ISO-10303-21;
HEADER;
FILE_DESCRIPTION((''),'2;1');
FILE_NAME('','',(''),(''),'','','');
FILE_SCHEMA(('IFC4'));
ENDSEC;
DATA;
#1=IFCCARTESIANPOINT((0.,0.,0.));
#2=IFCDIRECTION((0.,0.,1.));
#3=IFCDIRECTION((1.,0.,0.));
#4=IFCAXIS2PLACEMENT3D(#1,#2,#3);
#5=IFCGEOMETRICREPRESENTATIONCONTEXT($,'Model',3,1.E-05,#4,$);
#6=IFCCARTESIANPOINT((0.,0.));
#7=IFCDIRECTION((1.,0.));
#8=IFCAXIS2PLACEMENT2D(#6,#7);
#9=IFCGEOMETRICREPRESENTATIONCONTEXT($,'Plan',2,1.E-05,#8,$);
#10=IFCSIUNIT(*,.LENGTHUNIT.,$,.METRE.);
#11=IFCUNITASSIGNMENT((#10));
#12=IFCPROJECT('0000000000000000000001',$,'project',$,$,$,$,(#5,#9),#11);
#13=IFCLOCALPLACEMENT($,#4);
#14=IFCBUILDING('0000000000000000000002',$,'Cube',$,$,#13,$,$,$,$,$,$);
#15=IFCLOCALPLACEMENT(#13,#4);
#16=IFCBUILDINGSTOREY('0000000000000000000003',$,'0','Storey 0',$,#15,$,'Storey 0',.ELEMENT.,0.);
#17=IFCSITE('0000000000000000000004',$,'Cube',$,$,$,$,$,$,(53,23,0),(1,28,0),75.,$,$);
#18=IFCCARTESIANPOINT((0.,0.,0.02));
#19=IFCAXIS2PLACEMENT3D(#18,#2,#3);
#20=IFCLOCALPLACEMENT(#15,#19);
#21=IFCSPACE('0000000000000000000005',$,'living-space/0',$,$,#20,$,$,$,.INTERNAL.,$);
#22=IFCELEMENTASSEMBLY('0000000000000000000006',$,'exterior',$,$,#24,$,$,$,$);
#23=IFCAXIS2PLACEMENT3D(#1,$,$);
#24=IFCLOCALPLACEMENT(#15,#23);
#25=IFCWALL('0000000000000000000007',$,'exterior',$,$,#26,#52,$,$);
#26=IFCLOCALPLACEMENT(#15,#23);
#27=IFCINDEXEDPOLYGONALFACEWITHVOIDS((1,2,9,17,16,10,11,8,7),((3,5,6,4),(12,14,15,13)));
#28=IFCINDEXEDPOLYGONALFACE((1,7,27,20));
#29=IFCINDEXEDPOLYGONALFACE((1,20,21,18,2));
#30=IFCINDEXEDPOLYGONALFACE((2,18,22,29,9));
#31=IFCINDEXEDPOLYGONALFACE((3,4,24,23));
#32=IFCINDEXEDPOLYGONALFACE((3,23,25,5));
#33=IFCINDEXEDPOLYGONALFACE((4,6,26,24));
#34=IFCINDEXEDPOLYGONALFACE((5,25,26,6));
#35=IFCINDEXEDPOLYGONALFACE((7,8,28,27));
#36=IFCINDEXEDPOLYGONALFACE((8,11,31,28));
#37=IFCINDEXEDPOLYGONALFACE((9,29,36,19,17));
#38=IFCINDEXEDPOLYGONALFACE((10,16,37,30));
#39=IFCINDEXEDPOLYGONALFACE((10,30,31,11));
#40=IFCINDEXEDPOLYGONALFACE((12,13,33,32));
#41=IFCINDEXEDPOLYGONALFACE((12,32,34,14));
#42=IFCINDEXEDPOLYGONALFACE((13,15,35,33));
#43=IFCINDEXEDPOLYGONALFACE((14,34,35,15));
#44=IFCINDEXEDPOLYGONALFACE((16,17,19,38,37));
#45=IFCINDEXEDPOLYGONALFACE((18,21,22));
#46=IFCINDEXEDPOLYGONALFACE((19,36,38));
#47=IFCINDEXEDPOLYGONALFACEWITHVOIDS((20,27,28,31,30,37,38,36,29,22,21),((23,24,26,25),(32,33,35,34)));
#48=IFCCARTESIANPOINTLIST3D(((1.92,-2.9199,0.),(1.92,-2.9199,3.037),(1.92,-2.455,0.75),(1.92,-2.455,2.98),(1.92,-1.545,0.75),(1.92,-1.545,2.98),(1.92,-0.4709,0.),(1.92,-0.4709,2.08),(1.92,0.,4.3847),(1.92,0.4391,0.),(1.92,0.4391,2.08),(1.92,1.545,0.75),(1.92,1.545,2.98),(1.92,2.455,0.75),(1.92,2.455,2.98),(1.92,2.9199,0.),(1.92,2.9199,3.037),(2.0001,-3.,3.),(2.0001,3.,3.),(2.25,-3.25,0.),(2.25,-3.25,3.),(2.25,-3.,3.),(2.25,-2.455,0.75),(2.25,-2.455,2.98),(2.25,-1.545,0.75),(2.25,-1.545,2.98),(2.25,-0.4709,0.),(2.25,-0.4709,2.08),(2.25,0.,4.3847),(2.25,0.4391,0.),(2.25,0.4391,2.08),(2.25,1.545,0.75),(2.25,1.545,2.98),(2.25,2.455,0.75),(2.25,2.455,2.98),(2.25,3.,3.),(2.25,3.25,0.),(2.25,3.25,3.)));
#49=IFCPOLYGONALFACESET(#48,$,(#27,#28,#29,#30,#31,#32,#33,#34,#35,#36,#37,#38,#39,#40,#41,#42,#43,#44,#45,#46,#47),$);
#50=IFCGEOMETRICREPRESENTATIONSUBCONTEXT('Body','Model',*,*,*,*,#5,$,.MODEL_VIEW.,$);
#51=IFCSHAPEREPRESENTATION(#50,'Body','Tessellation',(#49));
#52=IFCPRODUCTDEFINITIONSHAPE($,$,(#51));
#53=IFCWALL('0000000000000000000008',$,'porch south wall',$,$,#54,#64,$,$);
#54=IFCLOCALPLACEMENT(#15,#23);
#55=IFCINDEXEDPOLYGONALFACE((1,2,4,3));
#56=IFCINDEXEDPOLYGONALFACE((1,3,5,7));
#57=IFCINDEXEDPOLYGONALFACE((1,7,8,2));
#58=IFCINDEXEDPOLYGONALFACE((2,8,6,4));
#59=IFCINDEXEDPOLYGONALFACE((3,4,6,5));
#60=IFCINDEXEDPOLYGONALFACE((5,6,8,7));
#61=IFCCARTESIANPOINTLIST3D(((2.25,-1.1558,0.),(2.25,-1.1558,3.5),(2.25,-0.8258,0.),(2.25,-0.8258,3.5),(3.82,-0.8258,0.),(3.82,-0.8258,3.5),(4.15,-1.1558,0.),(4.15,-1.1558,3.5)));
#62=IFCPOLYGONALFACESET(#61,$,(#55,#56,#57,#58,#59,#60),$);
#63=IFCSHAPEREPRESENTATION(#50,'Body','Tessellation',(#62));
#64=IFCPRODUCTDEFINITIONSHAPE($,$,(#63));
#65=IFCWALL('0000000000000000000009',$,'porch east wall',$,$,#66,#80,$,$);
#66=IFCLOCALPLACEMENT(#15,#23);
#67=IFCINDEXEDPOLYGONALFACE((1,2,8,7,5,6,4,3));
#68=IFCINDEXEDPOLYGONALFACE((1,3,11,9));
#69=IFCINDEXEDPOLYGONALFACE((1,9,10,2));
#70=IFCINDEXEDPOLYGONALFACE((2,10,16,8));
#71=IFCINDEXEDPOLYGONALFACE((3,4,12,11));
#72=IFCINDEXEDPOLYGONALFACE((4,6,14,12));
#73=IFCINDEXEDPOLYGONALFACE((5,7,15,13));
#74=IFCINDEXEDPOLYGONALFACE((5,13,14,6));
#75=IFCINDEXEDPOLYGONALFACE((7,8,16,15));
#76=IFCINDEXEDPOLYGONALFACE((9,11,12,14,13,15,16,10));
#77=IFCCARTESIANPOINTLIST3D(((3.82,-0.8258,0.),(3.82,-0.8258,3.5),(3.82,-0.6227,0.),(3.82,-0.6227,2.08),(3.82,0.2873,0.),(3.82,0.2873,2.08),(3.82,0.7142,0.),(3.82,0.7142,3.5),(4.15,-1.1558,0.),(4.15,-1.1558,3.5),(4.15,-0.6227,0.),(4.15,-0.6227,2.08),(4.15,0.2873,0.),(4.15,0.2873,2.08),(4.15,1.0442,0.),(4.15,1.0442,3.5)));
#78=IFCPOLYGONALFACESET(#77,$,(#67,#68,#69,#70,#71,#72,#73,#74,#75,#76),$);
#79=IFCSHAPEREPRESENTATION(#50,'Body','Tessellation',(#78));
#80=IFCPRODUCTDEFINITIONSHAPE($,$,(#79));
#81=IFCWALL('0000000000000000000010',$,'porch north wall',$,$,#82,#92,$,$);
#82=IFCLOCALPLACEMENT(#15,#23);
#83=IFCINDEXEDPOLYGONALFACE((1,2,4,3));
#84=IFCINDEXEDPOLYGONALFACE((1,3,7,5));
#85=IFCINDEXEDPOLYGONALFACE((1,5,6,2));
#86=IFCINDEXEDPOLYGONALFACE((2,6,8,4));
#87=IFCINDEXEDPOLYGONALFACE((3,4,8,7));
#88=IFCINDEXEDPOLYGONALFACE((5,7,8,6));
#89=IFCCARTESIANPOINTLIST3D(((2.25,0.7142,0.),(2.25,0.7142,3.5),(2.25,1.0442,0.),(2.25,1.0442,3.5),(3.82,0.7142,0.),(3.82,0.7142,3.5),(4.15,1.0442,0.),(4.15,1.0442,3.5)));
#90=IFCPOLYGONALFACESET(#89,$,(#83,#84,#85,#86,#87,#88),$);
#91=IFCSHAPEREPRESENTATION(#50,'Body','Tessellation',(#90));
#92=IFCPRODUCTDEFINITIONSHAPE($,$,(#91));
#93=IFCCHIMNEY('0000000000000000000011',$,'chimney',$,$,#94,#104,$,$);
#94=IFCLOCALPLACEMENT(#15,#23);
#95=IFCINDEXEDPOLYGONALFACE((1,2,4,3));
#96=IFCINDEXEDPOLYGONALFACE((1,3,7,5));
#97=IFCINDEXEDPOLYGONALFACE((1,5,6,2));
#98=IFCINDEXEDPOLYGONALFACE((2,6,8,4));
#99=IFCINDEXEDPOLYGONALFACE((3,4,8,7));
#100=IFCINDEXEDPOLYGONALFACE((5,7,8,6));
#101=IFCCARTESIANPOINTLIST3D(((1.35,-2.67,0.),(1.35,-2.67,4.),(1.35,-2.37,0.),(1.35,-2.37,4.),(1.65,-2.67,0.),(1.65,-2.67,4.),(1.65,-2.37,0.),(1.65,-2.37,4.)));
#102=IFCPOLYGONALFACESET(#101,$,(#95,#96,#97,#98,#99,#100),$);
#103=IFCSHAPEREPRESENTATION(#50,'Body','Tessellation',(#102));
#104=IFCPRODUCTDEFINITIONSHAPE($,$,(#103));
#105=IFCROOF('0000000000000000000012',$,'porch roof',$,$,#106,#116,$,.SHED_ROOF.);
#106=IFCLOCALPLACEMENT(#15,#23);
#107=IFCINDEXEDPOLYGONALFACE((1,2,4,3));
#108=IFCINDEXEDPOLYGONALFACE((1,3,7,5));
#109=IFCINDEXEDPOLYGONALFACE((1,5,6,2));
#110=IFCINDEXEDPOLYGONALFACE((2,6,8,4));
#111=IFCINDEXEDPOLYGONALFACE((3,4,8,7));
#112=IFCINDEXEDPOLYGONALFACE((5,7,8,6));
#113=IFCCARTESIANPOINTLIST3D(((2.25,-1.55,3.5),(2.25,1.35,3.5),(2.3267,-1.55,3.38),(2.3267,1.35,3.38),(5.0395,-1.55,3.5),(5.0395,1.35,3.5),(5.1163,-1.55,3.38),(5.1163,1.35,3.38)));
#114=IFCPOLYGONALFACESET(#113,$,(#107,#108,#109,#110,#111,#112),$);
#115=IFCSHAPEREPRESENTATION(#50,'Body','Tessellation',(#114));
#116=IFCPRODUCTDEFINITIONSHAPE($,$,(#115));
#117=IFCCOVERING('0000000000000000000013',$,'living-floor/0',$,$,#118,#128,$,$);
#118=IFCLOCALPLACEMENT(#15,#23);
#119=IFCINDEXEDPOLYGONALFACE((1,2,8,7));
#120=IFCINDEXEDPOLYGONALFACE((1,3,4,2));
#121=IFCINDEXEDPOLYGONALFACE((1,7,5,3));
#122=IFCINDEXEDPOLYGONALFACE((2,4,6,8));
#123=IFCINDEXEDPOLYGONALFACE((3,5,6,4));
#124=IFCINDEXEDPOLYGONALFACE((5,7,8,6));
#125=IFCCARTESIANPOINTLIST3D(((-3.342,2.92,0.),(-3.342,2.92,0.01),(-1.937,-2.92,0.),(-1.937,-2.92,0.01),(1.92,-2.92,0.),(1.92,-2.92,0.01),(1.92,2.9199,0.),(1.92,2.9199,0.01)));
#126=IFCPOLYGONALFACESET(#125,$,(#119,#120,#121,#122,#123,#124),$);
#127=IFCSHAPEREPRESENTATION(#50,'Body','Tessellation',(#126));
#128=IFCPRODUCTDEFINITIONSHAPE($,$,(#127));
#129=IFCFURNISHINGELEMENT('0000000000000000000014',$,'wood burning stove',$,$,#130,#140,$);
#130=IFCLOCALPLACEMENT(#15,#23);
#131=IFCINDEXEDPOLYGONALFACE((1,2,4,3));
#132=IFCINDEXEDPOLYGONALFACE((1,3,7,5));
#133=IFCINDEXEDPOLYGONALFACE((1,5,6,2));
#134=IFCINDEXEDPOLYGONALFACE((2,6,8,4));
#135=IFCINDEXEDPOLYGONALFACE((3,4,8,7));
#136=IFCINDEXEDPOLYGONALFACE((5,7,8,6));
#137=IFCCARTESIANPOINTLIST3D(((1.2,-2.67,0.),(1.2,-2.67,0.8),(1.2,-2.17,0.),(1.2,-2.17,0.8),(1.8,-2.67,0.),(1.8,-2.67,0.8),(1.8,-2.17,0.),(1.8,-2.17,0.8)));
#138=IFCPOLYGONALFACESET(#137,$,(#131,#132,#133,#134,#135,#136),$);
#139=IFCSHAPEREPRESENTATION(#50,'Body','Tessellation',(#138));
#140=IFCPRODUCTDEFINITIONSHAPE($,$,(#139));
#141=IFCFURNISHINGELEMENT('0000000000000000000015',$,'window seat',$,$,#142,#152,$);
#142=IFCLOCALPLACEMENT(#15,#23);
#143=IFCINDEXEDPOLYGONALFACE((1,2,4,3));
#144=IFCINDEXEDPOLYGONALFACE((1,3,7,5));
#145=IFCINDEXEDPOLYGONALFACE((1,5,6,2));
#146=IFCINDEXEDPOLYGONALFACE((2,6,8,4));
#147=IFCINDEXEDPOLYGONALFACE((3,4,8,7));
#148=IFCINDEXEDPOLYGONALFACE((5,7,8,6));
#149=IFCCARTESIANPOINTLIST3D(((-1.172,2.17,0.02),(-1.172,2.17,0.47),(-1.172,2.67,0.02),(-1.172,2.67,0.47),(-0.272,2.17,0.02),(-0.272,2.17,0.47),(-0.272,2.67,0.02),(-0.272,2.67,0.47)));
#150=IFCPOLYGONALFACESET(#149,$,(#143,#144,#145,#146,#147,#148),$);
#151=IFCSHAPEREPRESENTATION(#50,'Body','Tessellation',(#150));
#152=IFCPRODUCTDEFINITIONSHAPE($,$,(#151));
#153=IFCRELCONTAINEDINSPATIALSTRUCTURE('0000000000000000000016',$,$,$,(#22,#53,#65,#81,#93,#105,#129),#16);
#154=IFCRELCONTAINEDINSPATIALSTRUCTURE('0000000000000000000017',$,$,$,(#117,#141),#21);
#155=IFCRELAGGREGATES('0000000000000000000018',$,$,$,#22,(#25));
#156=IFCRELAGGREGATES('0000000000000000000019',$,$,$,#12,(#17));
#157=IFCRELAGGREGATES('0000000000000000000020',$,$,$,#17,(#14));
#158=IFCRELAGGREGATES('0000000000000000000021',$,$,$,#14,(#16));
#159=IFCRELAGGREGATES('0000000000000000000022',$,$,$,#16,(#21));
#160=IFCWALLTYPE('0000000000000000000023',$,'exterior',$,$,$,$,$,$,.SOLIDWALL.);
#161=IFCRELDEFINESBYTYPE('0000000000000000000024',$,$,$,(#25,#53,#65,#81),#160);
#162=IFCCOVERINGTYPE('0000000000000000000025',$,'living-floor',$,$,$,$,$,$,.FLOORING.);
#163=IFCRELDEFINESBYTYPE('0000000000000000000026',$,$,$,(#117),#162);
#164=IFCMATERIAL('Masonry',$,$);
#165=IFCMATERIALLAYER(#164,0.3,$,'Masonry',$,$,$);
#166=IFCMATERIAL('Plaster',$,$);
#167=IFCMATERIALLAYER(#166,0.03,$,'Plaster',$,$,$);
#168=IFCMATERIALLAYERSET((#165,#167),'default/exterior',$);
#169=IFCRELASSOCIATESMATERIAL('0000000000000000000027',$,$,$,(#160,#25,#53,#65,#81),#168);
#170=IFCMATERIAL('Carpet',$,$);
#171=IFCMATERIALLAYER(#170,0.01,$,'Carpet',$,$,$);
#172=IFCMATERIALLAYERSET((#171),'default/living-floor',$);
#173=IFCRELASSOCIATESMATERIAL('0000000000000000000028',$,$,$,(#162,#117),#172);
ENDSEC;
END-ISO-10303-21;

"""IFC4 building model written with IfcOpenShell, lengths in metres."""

from ifc_helpers import new_model, si_unit, frame, origin, origin_with_axes, origin_2d_with_axis, place, context, subcontext, project, spatial, polyline, line, indexed_curve, outline, extrude, clip, bounded_halfspace, source, transform, mapped, material, layer, layer_set, layer_usage, type_object, element, aggregate, save


model = new_model("IFC4")

# Units and contexts
model_context = context("Model", 3, precision=1e-05, world=origin_with_axes())
plan_context = context("Plan", 2, precision=1e-05, world=origin_2d_with_axis())
body_context = subcontext(model_context, "Body", "Model", "MODEL_VIEW")
ifc_project = project(units=[si_unit("LENGTHUNIT", "METRE")], contexts=[model_context, plan_context])

# Site, building, storey
site = spatial("IfcSite", under=ifc_project, Name="Cube", RefLatitude=(53, 23, 0), RefLongitude=(1, 28, 0), RefElevation=75.0)
building_placement = place(None, origin_with_axes())
building = spatial("IfcBuilding", under=site, at=building_placement, Name="Cube")
storey_placement = place(building_placement, origin_with_axes())
storey = spatial("IfcBuildingStorey", under=building, at=storey_placement, Name="0", Description="Storey 0", LongName="Storey 0", CompositionType="ELEMENT", Elevation=0.0)

# Element assembly, wall, openings
ifc_material_1 = material(Name="Masonry")
ifc_layer_1 = layer(ifc_material_1, 0.3, Name="Masonry")
ifc_material_2 = material(Name="Plaster")
ifc_layer_2 = layer(ifc_material_2, 0.03, Name="Plaster")
ifc_layer_set_1 = layer_set([ifc_layer_1, ifc_layer_2], Name="default/exterior")
wall_type = type_object("IfcWallType", Name="exterior", PredefinedType="SOLIDWALL", material=ifc_layer_set_1)
assembly_1_placement = place(storey_placement, frame((2.0, -3.0, 0.0), z_axis=(0.0, 0.0, 1.0), x_axis=(0.0, 1.0, 0.0)))
assembly_1 = element("IfcElementAssembly", 1, at=assembly_1_placement, inside=storey, Name="exterior")
ifc_layer_usage_1 = layer_usage(ifc_layer_set_1, "AXIS2", "POSITIVE", -0.25)
wall_1_placement = place(assembly_1_placement, origin_with_axes())
wall_1 = element("IfcWall", 2, at=wall_1_placement, type_object=wall_type, material=ifc_layer_usage_1, Name="exterior", context=body_context, shape_type="Clipping", body=[
    clip(clip(clip(clip(extrude(outline(polyline([(0.0801, 0.08), (-0.25, -0.25), (6.25, -0.25), (5.9199, 0.08), (0.0801, 0.08)])), origin(), (0.0, 0.0, 1.0), 4.385), bounded_halfspace(frame((6.0, 0.0, 3.0), z_axis=(0.419069, 0.0, 0.907954), x_axis=(0.0, -1.0, 0.0)), False, origin(), polyline([(6.0, -1.0), (3.0, -1.0), (3.0, 1.0), (6.0, 1.0), (6.0, -1.0)]))), bounded_halfspace(frame((6.0, 0.0, 3.0), z_axis=(0.0, 0.0, 1.0), x_axis=(0.0, 1.0, 0.0)), False, origin(), polyline([(6.0, 1.0), (7.0, 1.0), (7.0, -1.0), (6.0, -1.0), (6.0, 1.0)]))), bounded_halfspace(frame((3.0, 0.0, 4.3847), z_axis=(-0.419069, 0.0, 0.907954), x_axis=(0.0, -1.0, 0.0)), False, origin(), polyline([(3.0, -1.0), (0.0, -1.0), (0.0, 1.0), (3.0, 1.0), (3.0, -1.0)]))), bounded_halfspace(frame((0.0, 0.0, 3.0), z_axis=(0.0, 0.0, 1.0), x_axis=(0.0, -1.0, 0.0)), False, origin(), polyline([(0.0, -1.0), (-1.0, -1.0), (-1.0, 1.0), (0.0, 1.0), (0.0, -1.0)]))),
])
opening_1_placement = place(wall_1_placement, frame((0.545, -0.25, 0.75), z_axis=(0.0, 0.0, 1.0), x_axis=(1.0, 0.0, 0.0)))
element("IfcOpeningElement", 3, at=opening_1_placement, cuts=wall_1, PredefinedType="OPENING", context=body_context, shape_type="SweptSolid", body=[
    extrude(outline(polyline([(0.0, -0.02), (0.91, -0.02), (0.91, 0.35), (0.0, 0.35), (0.0, -0.02)])), origin(), (0.0, 0.0, 1.0), 2.23),
])
opening_2_placement = place(wall_1_placement, frame((4.545, -0.25, 0.75), z_axis=(0.0, 0.0, 1.0), x_axis=(1.0, 0.0, 0.0)))
element("IfcOpeningElement", 4, at=opening_2_placement, cuts=wall_1, PredefinedType="OPENING", context=body_context, shape_type="SweptSolid", body=[
    extrude(outline(polyline([(0.0, -0.02), (0.91, -0.02), (0.91, 0.35), (0.0, 0.35), (0.0, -0.02)])), origin(), (0.0, 0.0, 1.0), 2.23),
])
shared_shape_1 = source(origin_with_axes(), body_context, "Body", "SweptSolid", [
    extrude(outline(indexed_curve([(0.0, 0.0), (0.91, 0.0), (0.91, 2.08), (0.0, 2.08)], segments=[line(1, 2, 3, 4, 1)])), frame((0.0, -0.6, 0.0), z_axis=(0.0, -1.0, 0.0), x_axis=(1.0, 0.0, 0.0)), (0.0, 0.0, -1.0), 1.2),
])
opening_3_placement = place(wall_1_placement, frame((2.5291, -0.25, 0.0), z_axis=(0.0, 0.0, 1.0), x_axis=(1.0, 0.0, 0.0)))
element("IfcOpeningElement", 5, at=opening_3_placement, cuts=wall_1, PredefinedType="OPENING", context=body_context, shape_type="MappedRepresentation", body=[
    mapped(shared_shape_1, transform((0.0, 0.0, 0.0), x_axis=(1.0, 0.0, 0.0), y_axis=(0.0, 1.0, 0.0), z_axis=(0.0, 0.0, 1.0), scale=1.0)),
])
aggregate(assembly_1, [wall_1])

# Wall
ifc_layer_usage_2 = layer_usage(ifc_layer_set_1, "AXIS2", "POSITIVE", 0.0)
wall_2_placement = place(storey_placement, frame((2.25, -1.1558, 0.0), z_axis=(0.0, 0.0, 1.0), x_axis=(1.0, 0.0, 0.0)))
element("IfcWall", 6, at=wall_2_placement, inside=storey, type_object=wall_type, material=ifc_layer_usage_2, Name="porch south wall", context=body_context, shape_type="SweptSolid", body=[
    extrude(outline(indexed_curve([(0.0, 0.0), (0.0, 0.33), (1.57, 0.33), (1.9, 0.0)], segments=[line(1, 2, 3, 4, 1)])), origin_with_axes(), (0.0, 0.0, 1.0), 3.5),
])

# Wall, opening
ifc_layer_usage_3 = layer_usage(ifc_layer_set_1, "AXIS2", "POSITIVE", 0.0)
wall_3_placement = place(storey_placement, frame((4.15, -1.1558, 0.0), z_axis=(0.0, 0.0, 1.0), x_axis=(0.0, 1.0, 0.0)))
wall_3 = element("IfcWall", 7, at=wall_3_placement, inside=storey, type_object=wall_type, material=ifc_layer_usage_3, Name="porch east wall", context=body_context, shape_type="SweptSolid", body=[
    extrude(outline(indexed_curve([(0.0, 0.0), (0.33, 0.33), (1.87, 0.33), (2.2, 0.0)], segments=[line(1, 2, 3, 4, 1)])), origin_with_axes(), (0.0, 0.0, 1.0), 3.5),
])
shared_shape_2 = source(origin_with_axes(), body_context, "Body", "SweptSolid", [
    extrude(outline(indexed_curve([(0.0, 0.0), (0.91, 0.0), (0.91, 2.08), (0.0, 2.08)], segments=[line(1, 2, 3, 4, 1)])), frame((0.0, -0.6, 0.0), z_axis=(0.0, -1.0, 0.0), x_axis=(1.0, 0.0, 0.0)), (0.0, 0.0, -1.0), 1.2),
])
opening_4_placement = place(wall_3_placement, frame((0.5331, 0.0, 0.0), z_axis=(0.0, 0.0, 1.0), x_axis=(1.0, 0.0, 0.0)))
element("IfcOpeningElement", 8, at=opening_4_placement, cuts=wall_3, PredefinedType="OPENING", context=body_context, shape_type="MappedRepresentation", body=[
    mapped(shared_shape_2, transform((0.0, 0.0, 0.0), x_axis=(1.0, 0.0, 0.0), y_axis=(0.0, 1.0, 0.0), z_axis=(0.0, 0.0, 1.0), scale=1.0)),
])

# Wall
ifc_layer_usage_4 = layer_usage(ifc_layer_set_1, "AXIS2", "POSITIVE", 0.0)
wall_4_placement = place(storey_placement, frame((4.15, 1.0442, 0.0), z_axis=(0.0, 0.0, 1.0), x_axis=(-1.0, 0.0, 0.0)))
element("IfcWall", 9, at=wall_4_placement, inside=storey, type_object=wall_type, material=ifc_layer_usage_4, Name="porch north wall", context=body_context, shape_type="SweptSolid", body=[
    extrude(outline(indexed_curve([(0.0, 0.0), (0.33, 0.33), (1.9, 0.33), (1.9, 0.0)], segments=[line(1, 2, 3, 4, 1)])), origin_with_axes(), (0.0, 0.0, 1.0), 3.5),
])

# Chimney
chimney_placement = place(storey_placement, frame((1.35, -2.67, 0.0), z_axis=(0.0, 0.0, 1.0), x_axis=(1.0, 0.0, 0.0)))
element("IfcChimney", 10, at=chimney_placement, inside=storey, Name="chimney", context=body_context, shape_type="SweptSolid", body=[
    extrude(outline(indexed_curve([(0.0, 0.0), (0.3, 0.0), (0.3, 0.3), (0.0, 0.3)])), None, (0.0, 0.0, 1.0), 4.0),
])

# Roof
roof_placement = place(storey_placement, frame((2.25, 1.35, 3.5), z_axis=(0.0, 0.0, 1.0), x_axis=(0.0, -1.0, 0.0)))
element("IfcRoof", 11, at=roof_placement, inside=storey, Name="porch roof", PredefinedType="SHED_ROOF", context=body_context, shape_type="SweptSolid", body=[
    extrude(outline(indexed_curve([(0.0, 0.0), (2.9, 0.0), (2.9, 2.7895), (0.0, 2.7895)])), None, (0.0, 0.53879, -0.84244), 0.1424),
])

# Shared definitions
space_placement = place(storey_placement, frame((0.0, 0.0, 0.02), z_axis=(0.0, 0.0, 1.0), x_axis=(1.0, 0.0, 0.0)))
space = spatial("IfcSpace", under=storey, at=space_placement, Name="living-space/0", PredefinedType="INTERNAL")

# Covering
ifc_material_3 = material(Name="Carpet")
ifc_layer_3 = layer(ifc_material_3, 0.01, Name="Carpet")
ifc_layer_set_2 = layer_set([ifc_layer_3], Name="default/living-floor")
ifc_layer_usage_5 = layer_usage(ifc_layer_set_2, "AXIS3", "POSITIVE", 0.0)
covering_type = type_object("IfcCoveringType", Name="living-floor", PredefinedType="FLOORING", material=ifc_layer_set_2)
covering_placement = place(space_placement, frame((0.0, 0.0, -0.02), z_axis=(0.0, 0.0, 1.0), x_axis=(1.0, 0.0, 0.0)))
element("IfcCovering", 12, at=covering_placement, inside=space, type_object=covering_type, material=ifc_layer_usage_5, Name="living-floor/0", context=body_context, shape_type="SweptSolid", body=[
    extrude(outline(polyline([(1.92, 2.9199), (-3.342, 2.92), (-1.937, -2.92), (1.92, -2.92), (1.92, 2.9199)])), origin_with_axes(), (0.0, 0.0, 1.0), 0.01),
])

# Furnishing elements
furnishing_1_placement = place(storey_placement, frame((1.2, -2.67, 0.0), z_axis=(0.0, 0.0, 1.0), x_axis=(1.0, 0.0, 0.0)))
element("IfcFurnishingElement", 13, at=furnishing_1_placement, inside=storey, Name="wood burning stove", context=body_context, shape_type="SweptSolid", body=[
    extrude(outline(indexed_curve([(0.0, 0.0), (0.6, 0.0), (0.6, 0.5), (0.0, 0.5)])), None, (0.0, 0.0, 1.0), 0.8),
])
furnishing_2_placement = place(space_placement, frame((-1.172, 2.17, 0.0), z_axis=(0.0, 0.0, 1.0), x_axis=(1.0, 0.0, 0.0)))
element("IfcFurnishingElement", 14, at=furnishing_2_placement, inside=space, Name="window seat", context=body_context, shape_type="SweptSolid", body=[
    extrude(outline(indexed_curve([(0.0, 0.0), (0.9, 0.0), (0.9, 0.5), (0.0, 0.5)])), None, (0.0, 0.0, 1.0), 0.45),
])

save(model, "model.ifc")
